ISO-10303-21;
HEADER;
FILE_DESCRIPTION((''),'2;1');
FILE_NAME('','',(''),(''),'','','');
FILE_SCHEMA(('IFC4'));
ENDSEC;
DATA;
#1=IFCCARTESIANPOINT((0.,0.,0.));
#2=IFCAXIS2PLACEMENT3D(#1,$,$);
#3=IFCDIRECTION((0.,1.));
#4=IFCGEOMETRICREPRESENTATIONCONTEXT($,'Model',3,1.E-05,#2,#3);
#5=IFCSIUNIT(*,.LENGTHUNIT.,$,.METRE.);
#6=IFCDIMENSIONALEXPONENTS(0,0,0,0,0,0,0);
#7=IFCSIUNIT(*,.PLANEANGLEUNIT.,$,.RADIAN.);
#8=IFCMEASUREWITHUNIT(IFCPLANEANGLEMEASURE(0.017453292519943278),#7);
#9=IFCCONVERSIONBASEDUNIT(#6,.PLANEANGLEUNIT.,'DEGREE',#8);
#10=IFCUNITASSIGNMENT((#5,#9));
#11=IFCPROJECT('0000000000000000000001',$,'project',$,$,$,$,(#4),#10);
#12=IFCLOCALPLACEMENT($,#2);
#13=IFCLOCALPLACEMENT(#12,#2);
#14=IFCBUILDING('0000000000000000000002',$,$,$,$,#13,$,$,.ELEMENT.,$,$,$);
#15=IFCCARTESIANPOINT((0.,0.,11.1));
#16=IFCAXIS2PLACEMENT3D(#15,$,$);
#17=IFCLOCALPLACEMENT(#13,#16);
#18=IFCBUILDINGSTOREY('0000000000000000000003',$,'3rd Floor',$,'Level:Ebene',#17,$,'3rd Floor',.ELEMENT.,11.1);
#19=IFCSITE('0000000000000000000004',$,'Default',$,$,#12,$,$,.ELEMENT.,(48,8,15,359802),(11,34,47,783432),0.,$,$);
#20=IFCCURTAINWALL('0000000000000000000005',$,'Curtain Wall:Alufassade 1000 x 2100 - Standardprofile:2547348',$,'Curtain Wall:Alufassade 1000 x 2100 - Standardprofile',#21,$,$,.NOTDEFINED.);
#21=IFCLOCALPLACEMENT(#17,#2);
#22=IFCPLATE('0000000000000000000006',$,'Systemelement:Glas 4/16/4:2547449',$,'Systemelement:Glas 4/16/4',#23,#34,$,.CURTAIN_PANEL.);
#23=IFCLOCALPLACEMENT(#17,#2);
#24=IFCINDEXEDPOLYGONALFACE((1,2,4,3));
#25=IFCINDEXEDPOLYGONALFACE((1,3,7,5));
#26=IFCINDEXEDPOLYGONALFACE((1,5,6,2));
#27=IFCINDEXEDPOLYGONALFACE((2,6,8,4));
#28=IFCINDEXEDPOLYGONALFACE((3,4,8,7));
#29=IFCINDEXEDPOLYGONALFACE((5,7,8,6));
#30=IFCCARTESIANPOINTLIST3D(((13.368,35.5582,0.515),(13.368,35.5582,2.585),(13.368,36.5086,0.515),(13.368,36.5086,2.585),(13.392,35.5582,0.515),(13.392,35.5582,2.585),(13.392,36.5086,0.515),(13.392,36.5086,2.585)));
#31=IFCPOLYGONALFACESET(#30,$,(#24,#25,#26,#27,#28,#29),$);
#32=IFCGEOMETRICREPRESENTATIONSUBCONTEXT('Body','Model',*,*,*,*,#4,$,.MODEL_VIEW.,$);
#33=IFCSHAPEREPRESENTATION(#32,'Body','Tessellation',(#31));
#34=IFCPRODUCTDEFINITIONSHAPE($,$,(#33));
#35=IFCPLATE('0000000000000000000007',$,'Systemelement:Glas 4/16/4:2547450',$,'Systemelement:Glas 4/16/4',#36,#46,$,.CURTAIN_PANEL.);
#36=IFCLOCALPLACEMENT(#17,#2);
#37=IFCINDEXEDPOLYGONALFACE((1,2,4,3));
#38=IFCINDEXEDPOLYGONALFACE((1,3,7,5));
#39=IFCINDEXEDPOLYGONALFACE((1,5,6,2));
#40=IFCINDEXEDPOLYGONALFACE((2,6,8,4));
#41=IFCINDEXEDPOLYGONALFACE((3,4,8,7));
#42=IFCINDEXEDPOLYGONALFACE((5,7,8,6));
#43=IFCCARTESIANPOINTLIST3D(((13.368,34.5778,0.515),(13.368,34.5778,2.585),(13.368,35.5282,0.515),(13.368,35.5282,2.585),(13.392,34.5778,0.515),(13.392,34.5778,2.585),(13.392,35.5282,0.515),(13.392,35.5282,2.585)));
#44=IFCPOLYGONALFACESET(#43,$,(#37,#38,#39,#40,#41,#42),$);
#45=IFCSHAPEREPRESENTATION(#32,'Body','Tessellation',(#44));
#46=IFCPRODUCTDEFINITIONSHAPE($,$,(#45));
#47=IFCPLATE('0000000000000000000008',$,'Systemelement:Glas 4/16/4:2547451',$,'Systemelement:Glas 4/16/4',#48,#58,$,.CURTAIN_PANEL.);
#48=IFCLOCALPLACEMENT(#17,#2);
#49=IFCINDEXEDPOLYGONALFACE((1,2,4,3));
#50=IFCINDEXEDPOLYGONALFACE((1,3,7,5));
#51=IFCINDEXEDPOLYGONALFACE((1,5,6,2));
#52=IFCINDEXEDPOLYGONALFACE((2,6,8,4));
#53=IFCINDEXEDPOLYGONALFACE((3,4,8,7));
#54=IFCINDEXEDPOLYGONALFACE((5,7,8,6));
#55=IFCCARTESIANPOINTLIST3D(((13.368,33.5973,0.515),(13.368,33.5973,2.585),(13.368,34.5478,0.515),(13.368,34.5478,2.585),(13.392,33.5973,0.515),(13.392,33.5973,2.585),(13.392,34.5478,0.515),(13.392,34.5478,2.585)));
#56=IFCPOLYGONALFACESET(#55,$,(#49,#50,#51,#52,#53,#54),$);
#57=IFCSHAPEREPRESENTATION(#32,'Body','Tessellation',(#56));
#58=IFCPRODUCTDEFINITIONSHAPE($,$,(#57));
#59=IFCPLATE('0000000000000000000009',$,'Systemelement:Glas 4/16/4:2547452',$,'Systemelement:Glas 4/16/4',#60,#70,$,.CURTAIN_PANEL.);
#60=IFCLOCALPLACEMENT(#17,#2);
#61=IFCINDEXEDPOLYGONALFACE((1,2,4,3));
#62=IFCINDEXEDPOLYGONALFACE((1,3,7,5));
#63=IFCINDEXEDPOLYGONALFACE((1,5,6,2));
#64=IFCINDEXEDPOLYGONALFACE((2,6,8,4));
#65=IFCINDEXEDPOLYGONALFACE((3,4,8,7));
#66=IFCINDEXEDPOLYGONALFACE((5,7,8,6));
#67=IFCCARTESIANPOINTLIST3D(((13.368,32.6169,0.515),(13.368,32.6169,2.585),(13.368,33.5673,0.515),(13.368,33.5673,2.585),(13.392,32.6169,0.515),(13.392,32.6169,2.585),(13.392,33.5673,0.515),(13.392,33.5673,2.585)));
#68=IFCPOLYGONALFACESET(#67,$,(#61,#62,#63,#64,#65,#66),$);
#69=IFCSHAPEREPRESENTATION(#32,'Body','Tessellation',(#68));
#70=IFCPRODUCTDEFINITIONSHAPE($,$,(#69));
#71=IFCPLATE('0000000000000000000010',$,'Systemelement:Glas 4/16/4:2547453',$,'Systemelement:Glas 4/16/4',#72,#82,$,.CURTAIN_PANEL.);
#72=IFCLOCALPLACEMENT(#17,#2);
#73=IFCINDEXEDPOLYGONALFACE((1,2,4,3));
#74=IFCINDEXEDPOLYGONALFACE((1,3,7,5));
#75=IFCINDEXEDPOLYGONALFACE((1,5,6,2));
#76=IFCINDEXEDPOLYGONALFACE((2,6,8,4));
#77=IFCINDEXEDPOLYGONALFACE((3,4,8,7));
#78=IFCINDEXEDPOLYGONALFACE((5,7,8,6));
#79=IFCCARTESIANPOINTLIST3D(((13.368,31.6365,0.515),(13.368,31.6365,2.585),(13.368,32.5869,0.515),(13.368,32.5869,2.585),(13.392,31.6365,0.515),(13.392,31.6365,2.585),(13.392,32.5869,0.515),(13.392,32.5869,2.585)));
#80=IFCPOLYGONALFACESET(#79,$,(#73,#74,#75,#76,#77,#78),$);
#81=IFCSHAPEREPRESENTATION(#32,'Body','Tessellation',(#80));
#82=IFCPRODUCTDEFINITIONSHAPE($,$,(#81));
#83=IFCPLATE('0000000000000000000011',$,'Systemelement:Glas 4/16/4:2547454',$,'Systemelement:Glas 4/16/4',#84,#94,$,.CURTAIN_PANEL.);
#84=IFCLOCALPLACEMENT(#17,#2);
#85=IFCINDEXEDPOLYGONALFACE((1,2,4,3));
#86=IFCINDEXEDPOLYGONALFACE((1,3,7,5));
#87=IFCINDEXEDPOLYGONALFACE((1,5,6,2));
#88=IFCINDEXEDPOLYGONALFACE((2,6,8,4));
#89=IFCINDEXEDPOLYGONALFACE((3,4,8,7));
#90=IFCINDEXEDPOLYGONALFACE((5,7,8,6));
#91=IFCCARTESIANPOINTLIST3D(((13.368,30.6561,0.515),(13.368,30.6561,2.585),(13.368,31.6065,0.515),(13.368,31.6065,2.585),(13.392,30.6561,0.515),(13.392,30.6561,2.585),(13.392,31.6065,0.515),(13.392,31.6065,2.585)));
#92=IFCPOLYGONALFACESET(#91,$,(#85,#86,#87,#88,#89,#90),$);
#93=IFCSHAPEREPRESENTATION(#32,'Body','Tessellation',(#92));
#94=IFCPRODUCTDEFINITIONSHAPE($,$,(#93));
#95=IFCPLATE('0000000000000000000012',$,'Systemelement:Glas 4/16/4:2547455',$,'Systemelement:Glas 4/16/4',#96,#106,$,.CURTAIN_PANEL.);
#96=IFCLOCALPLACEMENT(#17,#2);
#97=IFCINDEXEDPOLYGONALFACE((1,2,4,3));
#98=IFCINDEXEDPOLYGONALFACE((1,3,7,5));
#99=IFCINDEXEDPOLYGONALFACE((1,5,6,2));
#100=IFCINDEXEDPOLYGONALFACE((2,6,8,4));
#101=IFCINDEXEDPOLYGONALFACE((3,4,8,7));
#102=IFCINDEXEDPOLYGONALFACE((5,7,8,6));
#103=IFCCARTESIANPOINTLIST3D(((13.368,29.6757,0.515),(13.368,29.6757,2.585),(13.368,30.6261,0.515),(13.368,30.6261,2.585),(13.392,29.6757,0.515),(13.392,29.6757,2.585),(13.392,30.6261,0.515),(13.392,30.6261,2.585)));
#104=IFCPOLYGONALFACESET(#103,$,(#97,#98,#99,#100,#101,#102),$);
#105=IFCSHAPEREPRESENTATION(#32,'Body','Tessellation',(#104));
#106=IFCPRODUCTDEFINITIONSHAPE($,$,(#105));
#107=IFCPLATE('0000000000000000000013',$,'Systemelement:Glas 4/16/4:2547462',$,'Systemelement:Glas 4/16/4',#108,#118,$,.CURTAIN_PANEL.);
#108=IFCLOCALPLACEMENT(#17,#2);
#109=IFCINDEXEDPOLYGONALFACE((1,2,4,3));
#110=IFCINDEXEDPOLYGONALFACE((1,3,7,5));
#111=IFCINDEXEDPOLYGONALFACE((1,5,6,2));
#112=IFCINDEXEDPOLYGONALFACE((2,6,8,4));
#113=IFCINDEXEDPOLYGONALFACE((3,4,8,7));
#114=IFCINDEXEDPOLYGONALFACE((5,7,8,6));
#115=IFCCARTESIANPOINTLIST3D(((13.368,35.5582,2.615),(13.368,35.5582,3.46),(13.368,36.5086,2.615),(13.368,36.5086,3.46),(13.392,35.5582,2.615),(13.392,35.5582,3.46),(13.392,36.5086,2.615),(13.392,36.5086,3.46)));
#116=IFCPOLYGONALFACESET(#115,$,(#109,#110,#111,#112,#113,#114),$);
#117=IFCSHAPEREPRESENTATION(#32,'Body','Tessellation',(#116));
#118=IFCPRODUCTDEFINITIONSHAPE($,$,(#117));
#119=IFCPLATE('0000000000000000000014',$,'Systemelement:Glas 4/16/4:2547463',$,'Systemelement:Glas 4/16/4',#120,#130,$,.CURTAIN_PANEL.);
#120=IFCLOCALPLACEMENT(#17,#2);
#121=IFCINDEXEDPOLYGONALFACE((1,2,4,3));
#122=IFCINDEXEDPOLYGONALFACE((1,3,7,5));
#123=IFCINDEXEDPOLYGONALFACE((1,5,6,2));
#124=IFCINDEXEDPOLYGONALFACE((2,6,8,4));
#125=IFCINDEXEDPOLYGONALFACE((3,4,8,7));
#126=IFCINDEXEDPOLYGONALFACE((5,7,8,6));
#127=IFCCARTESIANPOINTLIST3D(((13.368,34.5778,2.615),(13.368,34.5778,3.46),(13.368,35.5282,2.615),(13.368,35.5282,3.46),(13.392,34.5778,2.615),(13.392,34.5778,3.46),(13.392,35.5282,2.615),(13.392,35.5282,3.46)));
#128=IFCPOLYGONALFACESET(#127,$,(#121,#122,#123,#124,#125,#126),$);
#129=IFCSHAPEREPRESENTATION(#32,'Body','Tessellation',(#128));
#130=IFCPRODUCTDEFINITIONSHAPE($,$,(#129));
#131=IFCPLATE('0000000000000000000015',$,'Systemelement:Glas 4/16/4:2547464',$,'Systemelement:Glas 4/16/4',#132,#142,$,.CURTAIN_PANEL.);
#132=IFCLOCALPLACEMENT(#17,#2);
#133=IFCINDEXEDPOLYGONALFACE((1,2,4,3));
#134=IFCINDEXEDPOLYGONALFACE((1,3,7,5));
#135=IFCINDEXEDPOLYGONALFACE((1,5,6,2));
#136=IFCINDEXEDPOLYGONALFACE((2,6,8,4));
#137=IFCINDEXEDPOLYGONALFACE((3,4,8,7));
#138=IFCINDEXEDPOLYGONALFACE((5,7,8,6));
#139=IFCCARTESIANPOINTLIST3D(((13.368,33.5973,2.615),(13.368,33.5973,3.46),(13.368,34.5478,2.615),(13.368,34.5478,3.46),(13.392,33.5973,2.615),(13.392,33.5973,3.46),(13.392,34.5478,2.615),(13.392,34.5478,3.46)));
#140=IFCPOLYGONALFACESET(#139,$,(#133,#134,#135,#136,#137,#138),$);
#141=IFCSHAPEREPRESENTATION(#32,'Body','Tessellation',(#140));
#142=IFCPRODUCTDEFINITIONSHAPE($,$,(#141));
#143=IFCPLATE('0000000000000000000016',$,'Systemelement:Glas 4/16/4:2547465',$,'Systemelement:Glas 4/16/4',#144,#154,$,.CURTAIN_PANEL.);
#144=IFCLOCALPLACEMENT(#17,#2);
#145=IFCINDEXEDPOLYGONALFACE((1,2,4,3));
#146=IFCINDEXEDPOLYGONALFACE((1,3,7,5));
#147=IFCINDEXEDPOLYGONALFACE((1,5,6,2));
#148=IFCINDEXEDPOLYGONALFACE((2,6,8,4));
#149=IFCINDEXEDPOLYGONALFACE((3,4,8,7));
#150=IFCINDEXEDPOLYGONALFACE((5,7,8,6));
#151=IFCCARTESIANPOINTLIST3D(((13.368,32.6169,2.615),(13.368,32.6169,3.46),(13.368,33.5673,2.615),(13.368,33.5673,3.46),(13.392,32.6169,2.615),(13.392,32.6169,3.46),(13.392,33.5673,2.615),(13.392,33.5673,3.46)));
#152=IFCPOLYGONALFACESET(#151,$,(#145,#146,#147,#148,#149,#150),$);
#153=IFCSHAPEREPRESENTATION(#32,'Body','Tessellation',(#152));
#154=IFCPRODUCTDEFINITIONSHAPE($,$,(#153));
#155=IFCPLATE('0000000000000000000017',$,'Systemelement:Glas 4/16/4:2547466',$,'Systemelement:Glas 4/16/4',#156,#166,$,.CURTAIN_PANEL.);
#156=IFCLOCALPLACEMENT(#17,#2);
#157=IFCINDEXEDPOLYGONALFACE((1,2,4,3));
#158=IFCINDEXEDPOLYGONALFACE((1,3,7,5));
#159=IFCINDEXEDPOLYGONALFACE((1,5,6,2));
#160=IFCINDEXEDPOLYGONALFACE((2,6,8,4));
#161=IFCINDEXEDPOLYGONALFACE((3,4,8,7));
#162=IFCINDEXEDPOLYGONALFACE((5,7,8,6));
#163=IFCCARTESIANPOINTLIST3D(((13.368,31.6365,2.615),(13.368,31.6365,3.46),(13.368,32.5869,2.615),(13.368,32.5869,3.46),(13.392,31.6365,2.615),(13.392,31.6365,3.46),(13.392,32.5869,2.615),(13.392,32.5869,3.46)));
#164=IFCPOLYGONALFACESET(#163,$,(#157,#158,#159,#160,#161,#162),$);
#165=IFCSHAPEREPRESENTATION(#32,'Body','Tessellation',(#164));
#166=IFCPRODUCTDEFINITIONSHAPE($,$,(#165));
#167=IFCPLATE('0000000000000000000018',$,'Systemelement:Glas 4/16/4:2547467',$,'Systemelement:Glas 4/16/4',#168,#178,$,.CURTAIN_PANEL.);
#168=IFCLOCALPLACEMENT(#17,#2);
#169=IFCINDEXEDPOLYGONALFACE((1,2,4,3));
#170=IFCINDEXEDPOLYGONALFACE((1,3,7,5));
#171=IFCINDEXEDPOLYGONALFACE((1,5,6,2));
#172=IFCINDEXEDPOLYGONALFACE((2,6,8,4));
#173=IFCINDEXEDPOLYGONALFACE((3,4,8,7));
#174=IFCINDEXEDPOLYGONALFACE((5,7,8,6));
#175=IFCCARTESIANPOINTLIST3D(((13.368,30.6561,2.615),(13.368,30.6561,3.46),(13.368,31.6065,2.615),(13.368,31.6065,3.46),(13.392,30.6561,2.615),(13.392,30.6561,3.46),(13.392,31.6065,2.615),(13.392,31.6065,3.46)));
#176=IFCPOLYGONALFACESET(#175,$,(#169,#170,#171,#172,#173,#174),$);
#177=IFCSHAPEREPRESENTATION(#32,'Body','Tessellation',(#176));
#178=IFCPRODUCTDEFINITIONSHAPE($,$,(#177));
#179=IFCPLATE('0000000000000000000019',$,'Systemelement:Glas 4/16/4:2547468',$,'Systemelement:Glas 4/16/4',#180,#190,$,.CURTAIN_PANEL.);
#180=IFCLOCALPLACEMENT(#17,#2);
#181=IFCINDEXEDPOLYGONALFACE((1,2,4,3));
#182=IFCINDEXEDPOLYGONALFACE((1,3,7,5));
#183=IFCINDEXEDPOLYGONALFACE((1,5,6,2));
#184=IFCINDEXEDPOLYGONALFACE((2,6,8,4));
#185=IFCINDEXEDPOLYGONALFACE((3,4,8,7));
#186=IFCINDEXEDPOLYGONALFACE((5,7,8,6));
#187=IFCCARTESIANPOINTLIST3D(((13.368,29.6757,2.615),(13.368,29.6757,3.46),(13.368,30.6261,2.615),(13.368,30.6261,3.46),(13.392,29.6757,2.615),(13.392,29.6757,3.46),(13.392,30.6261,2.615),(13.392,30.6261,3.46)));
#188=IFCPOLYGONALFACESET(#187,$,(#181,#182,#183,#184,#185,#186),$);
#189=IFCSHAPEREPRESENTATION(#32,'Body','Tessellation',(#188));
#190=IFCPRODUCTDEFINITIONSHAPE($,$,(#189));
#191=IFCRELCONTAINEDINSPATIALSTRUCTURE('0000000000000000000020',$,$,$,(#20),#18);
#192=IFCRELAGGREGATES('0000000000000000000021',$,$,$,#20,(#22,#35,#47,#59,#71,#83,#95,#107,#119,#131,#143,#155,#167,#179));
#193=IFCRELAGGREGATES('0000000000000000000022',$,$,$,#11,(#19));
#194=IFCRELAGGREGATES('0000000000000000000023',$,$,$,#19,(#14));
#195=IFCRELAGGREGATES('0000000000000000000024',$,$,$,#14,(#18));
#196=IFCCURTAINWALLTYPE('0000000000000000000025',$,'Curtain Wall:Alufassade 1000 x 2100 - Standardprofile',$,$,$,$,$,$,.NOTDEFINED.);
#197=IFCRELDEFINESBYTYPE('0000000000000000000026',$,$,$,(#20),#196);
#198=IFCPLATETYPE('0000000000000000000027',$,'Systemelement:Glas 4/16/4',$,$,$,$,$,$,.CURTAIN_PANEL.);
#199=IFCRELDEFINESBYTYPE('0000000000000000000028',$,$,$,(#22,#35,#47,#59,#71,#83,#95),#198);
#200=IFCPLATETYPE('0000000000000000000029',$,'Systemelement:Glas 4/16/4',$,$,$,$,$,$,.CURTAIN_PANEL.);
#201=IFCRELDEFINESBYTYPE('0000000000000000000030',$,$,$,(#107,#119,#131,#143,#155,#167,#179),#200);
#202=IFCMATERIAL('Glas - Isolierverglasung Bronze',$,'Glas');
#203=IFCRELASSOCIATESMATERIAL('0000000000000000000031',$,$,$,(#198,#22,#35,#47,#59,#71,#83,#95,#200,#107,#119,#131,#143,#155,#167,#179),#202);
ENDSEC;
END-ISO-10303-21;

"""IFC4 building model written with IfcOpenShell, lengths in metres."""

from ifc_helpers import new_model, entity, si_unit, converted_unit, direction, frame, origin, place, context, subcontext, project, spatial, indexed_curve, outline, extrude, source, transform, mapped, material, type_object, type_shapes, element, aggregate, save


model = new_model("IFC4")

# Units and contexts
model_context = context("Model", 3, precision=1e-05, world=origin(), true_north=direction((0.0, 1.0)))
body_context = subcontext(model_context, "Body", "Model", "MODEL_VIEW")
ifc_project = project(units=[si_unit("LENGTHUNIT", "METRE"), converted_unit("PLANEANGLEUNIT", "DEGREE", entity("IfcPlaneAngleMeasure", 0.017453292519943278), si_unit("PLANEANGLEUNIT", "RADIAN"), dimensions=[0, 0, 0, 0, 0, 0, 0])], contexts=[model_context])

# Site, building, storey
site_placement = place(None, origin())
site = spatial("IfcSite", under=ifc_project, at=site_placement, Name="Default", CompositionType="ELEMENT", RefLatitude=(48, 8, 15, 359802), RefLongitude=(11, 34, 47, 783432), RefElevation=0.0)
building_placement = place(site_placement, origin())
building = spatial("IfcBuilding", under=site, at=building_placement, CompositionType="ELEMENT")
storey_placement = place(building_placement, frame((0.0, 0.0, 11.1)))
storey = spatial("IfcBuildingStorey", under=building, at=storey_placement, Name="3rd Floor", ObjectType="Level:Ebene", LongName="3rd Floor", CompositionType="ELEMENT", Elevation=11.1)

# Curtain wall, plates
curtain_wall_type = type_object("IfcCurtainWallType", Name="Curtain Wall:Alufassade 1000 x 2100 - Standardprofile", PredefinedType="NOTDEFINED")
curtain_wall_placement = place(storey_placement, frame((0.0, 0.0, -11.1)))
curtain_wall = element("IfcCurtainWall", 1, at=curtain_wall_placement, inside=storey, type_object=curtain_wall_type, Name="Curtain Wall:Alufassade 1000 x 2100 - Standardprofile:2547348", ObjectType="Curtain Wall:Alufassade 1000 x 2100 - Standardprofile", PredefinedType="NOTDEFINED")
ifc_material_1 = material(Name="Glas - Isolierverglasung Bronze", Category="Glas")
plate_type_1 = type_object("IfcPlateType", Name="Systemelement:Glas 4/16/4", PredefinedType="CURTAIN_PANEL", material=ifc_material_1)
shared_shape_1 = source(origin(), body_context, "Body", "SweptSolid", [
    extrude(outline(indexed_curve([(-0.012, -0.4752), (0.012, -0.4752), (0.012, 0.4752), (-0.012, 0.4752), (-0.012, -0.4752)], self_intersect=False)), frame((0.0, 0.0, 0.0), z_axis=(0.0, 0.0, 1.0), x_axis=(0.0, 1.0, 0.0)), (0.0, 0.0, 1.0), 2.07),
])
type_shapes(plate_type_1, [shared_shape_1])
plate_1_placement = place(curtain_wall_placement, frame((13.38, 36.0334, 11.615), z_axis=(0.0, 0.0, 1.0), x_axis=(0.0, -1.0, 0.0)))
plate_1 = element("IfcPlate", 2, at=plate_1_placement, type_object=plate_type_1, material=ifc_material_1, Name="Systemelement:Glas 4/16/4:2547449", ObjectType="Systemelement:Glas 4/16/4", PredefinedType="CURTAIN_PANEL", context=body_context, shape_type="MappedRepresentation", body=[
    mapped(shared_shape_1, transform((0.0, 0.0, 0.0), scale=1.0)),
])
plate_2_placement = place(curtain_wall_placement, frame((13.38, 35.053, 11.615), z_axis=(0.0, 0.0, 1.0), x_axis=(0.0, -1.0, 0.0)))
plate_2 = element("IfcPlate", 3, at=plate_2_placement, type_object=plate_type_1, material=ifc_material_1, Name="Systemelement:Glas 4/16/4:2547450", ObjectType="Systemelement:Glas 4/16/4", PredefinedType="CURTAIN_PANEL", context=body_context, shape_type="MappedRepresentation", body=[
    mapped(shared_shape_1, transform((0.0, 0.0, 0.0), scale=1.0)),
])
plate_3_placement = place(curtain_wall_placement, frame((13.38, 34.0725, 11.615), z_axis=(0.0, 0.0, 1.0), x_axis=(0.0, -1.0, 0.0)))
plate_3 = element("IfcPlate", 4, at=plate_3_placement, type_object=plate_type_1, material=ifc_material_1, Name="Systemelement:Glas 4/16/4:2547451", ObjectType="Systemelement:Glas 4/16/4", PredefinedType="CURTAIN_PANEL", context=body_context, shape_type="MappedRepresentation", body=[
    mapped(shared_shape_1, transform((0.0, 0.0, 0.0), scale=1.0)),
])
plate_4_placement = place(curtain_wall_placement, frame((13.38, 33.0921, 11.615), z_axis=(0.0, 0.0, 1.0), x_axis=(0.0, -1.0, 0.0)))
plate_4 = element("IfcPlate", 5, at=plate_4_placement, type_object=plate_type_1, material=ifc_material_1, Name="Systemelement:Glas 4/16/4:2547452", ObjectType="Systemelement:Glas 4/16/4", PredefinedType="CURTAIN_PANEL", context=body_context, shape_type="MappedRepresentation", body=[
    mapped(shared_shape_1, transform((0.0, 0.0, 0.0), scale=1.0)),
])
plate_5_placement = place(curtain_wall_placement, frame((13.38, 32.1117, 11.615), z_axis=(0.0, 0.0, 1.0), x_axis=(0.0, -1.0, 0.0)))
plate_5 = element("IfcPlate", 6, at=plate_5_placement, type_object=plate_type_1, material=ifc_material_1, Name="Systemelement:Glas 4/16/4:2547453", ObjectType="Systemelement:Glas 4/16/4", PredefinedType="CURTAIN_PANEL", context=body_context, shape_type="MappedRepresentation", body=[
    mapped(shared_shape_1, transform((0.0, 0.0, 0.0), scale=1.0)),
])
plate_6_placement = place(curtain_wall_placement, frame((13.38, 31.1313, 11.615), z_axis=(0.0, 0.0, 1.0), x_axis=(0.0, -1.0, 0.0)))
plate_6 = element("IfcPlate", 7, at=plate_6_placement, type_object=plate_type_1, material=ifc_material_1, Name="Systemelement:Glas 4/16/4:2547454", ObjectType="Systemelement:Glas 4/16/4", PredefinedType="CURTAIN_PANEL", context=body_context, shape_type="MappedRepresentation", body=[
    mapped(shared_shape_1, transform((0.0, 0.0, 0.0), scale=1.0)),
])
plate_7_placement = place(curtain_wall_placement, frame((13.38, 30.1509, 11.615), z_axis=(0.0, 0.0, 1.0), x_axis=(0.0, -1.0, 0.0)))
plate_7 = element("IfcPlate", 8, at=plate_7_placement, type_object=plate_type_1, material=ifc_material_1, Name="Systemelement:Glas 4/16/4:2547455", ObjectType="Systemelement:Glas 4/16/4", PredefinedType="CURTAIN_PANEL", context=body_context, shape_type="MappedRepresentation", body=[
    mapped(shared_shape_1, transform((0.0, 0.0, 0.0), scale=1.0)),
])
plate_type_2 = type_object("IfcPlateType", Name="Systemelement:Glas 4/16/4", PredefinedType="CURTAIN_PANEL", material=ifc_material_1)
shared_shape_2 = source(origin(), body_context, "Body", "SweptSolid", [
    extrude(outline(indexed_curve([(-0.012, -0.4752), (0.012, -0.4752), (0.012, 0.4752), (-0.012, 0.4752), (-0.012, -0.4752)], self_intersect=False)), frame((0.0, 0.0, 0.0), z_axis=(0.0, 0.0, 1.0), x_axis=(0.0, 1.0, 0.0)), (0.0, 0.0, 1.0), 0.845),
])
type_shapes(plate_type_2, [shared_shape_2])
plate_8_placement = place(curtain_wall_placement, frame((13.38, 36.0334, 13.715), z_axis=(0.0, 0.0, 1.0), x_axis=(0.0, -1.0, 0.0)))
plate_8 = element("IfcPlate", 9, at=plate_8_placement, type_object=plate_type_2, material=ifc_material_1, Name="Systemelement:Glas 4/16/4:2547462", ObjectType="Systemelement:Glas 4/16/4", PredefinedType="CURTAIN_PANEL", context=body_context, shape_type="MappedRepresentation", body=[
    mapped(shared_shape_2, transform((0.0, 0.0, 0.0), scale=1.0)),
])
plate_9_placement = place(curtain_wall_placement, frame((13.38, 35.053, 13.715), z_axis=(0.0, 0.0, 1.0), x_axis=(0.0, -1.0, 0.0)))
plate_9 = element("IfcPlate", 10, at=plate_9_placement, type_object=plate_type_2, material=ifc_material_1, Name="Systemelement:Glas 4/16/4:2547463", ObjectType="Systemelement:Glas 4/16/4", PredefinedType="CURTAIN_PANEL", context=body_context, shape_type="MappedRepresentation", body=[
    mapped(shared_shape_2, transform((0.0, 0.0, 0.0), scale=1.0)),
])
plate_10_placement = place(curtain_wall_placement, frame((13.38, 34.0725, 13.715), z_axis=(0.0, 0.0, 1.0), x_axis=(0.0, -1.0, 0.0)))
plate_10 = element("IfcPlate", 11, at=plate_10_placement, type_object=plate_type_2, material=ifc_material_1, Name="Systemelement:Glas 4/16/4:2547464", ObjectType="Systemelement:Glas 4/16/4", PredefinedType="CURTAIN_PANEL", context=body_context, shape_type="MappedRepresentation", body=[
    mapped(shared_shape_2, transform((0.0, 0.0, 0.0), scale=1.0)),
])
plate_11_placement = place(curtain_wall_placement, frame((13.38, 33.0921, 13.715), z_axis=(0.0, 0.0, 1.0), x_axis=(0.0, -1.0, 0.0)))
plate_11 = element("IfcPlate", 12, at=plate_11_placement, type_object=plate_type_2, material=ifc_material_1, Name="Systemelement:Glas 4/16/4:2547465", ObjectType="Systemelement:Glas 4/16/4", PredefinedType="CURTAIN_PANEL", context=body_context, shape_type="MappedRepresentation", body=[
    mapped(shared_shape_2, transform((0.0, 0.0, 0.0), scale=1.0)),
])
plate_12_placement = place(curtain_wall_placement, frame((13.38, 32.1117, 13.715), z_axis=(0.0, 0.0, 1.0), x_axis=(0.0, -1.0, 0.0)))
plate_12 = element("IfcPlate", 13, at=plate_12_placement, type_object=plate_type_2, material=ifc_material_1, Name="Systemelement:Glas 4/16/4:2547466", ObjectType="Systemelement:Glas 4/16/4", PredefinedType="CURTAIN_PANEL", context=body_context, shape_type="MappedRepresentation", body=[
    mapped(shared_shape_2, transform((0.0, 0.0, 0.0), scale=1.0)),
])
plate_13_placement = place(curtain_wall_placement, frame((13.38, 31.1313, 13.715), z_axis=(0.0, 0.0, 1.0), x_axis=(0.0, -1.0, 0.0)))
plate_13 = element("IfcPlate", 14, at=plate_13_placement, type_object=plate_type_2, material=ifc_material_1, Name="Systemelement:Glas 4/16/4:2547467", ObjectType="Systemelement:Glas 4/16/4", PredefinedType="CURTAIN_PANEL", context=body_context, shape_type="MappedRepresentation", body=[
    mapped(shared_shape_2, transform((0.0, 0.0, 0.0), scale=1.0)),
])
plate_14_placement = place(curtain_wall_placement, frame((13.38, 30.1509, 13.715), z_axis=(0.0, 0.0, 1.0), x_axis=(0.0, -1.0, 0.0)))
plate_14 = element("IfcPlate", 15, at=plate_14_placement, type_object=plate_type_2, material=ifc_material_1, Name="Systemelement:Glas 4/16/4:2547468", ObjectType="Systemelement:Glas 4/16/4", PredefinedType="CURTAIN_PANEL", context=body_context, shape_type="MappedRepresentation", body=[
    mapped(shared_shape_2, transform((0.0, 0.0, 0.0), scale=1.0)),
])
aggregate(curtain_wall, [plate_1, plate_2, plate_3, plate_4, plate_5, plate_6, plate_7, plate_8, plate_9, plate_10, plate_11, plate_12, plate_13, plate_14])

save(model, "model.ifc")
